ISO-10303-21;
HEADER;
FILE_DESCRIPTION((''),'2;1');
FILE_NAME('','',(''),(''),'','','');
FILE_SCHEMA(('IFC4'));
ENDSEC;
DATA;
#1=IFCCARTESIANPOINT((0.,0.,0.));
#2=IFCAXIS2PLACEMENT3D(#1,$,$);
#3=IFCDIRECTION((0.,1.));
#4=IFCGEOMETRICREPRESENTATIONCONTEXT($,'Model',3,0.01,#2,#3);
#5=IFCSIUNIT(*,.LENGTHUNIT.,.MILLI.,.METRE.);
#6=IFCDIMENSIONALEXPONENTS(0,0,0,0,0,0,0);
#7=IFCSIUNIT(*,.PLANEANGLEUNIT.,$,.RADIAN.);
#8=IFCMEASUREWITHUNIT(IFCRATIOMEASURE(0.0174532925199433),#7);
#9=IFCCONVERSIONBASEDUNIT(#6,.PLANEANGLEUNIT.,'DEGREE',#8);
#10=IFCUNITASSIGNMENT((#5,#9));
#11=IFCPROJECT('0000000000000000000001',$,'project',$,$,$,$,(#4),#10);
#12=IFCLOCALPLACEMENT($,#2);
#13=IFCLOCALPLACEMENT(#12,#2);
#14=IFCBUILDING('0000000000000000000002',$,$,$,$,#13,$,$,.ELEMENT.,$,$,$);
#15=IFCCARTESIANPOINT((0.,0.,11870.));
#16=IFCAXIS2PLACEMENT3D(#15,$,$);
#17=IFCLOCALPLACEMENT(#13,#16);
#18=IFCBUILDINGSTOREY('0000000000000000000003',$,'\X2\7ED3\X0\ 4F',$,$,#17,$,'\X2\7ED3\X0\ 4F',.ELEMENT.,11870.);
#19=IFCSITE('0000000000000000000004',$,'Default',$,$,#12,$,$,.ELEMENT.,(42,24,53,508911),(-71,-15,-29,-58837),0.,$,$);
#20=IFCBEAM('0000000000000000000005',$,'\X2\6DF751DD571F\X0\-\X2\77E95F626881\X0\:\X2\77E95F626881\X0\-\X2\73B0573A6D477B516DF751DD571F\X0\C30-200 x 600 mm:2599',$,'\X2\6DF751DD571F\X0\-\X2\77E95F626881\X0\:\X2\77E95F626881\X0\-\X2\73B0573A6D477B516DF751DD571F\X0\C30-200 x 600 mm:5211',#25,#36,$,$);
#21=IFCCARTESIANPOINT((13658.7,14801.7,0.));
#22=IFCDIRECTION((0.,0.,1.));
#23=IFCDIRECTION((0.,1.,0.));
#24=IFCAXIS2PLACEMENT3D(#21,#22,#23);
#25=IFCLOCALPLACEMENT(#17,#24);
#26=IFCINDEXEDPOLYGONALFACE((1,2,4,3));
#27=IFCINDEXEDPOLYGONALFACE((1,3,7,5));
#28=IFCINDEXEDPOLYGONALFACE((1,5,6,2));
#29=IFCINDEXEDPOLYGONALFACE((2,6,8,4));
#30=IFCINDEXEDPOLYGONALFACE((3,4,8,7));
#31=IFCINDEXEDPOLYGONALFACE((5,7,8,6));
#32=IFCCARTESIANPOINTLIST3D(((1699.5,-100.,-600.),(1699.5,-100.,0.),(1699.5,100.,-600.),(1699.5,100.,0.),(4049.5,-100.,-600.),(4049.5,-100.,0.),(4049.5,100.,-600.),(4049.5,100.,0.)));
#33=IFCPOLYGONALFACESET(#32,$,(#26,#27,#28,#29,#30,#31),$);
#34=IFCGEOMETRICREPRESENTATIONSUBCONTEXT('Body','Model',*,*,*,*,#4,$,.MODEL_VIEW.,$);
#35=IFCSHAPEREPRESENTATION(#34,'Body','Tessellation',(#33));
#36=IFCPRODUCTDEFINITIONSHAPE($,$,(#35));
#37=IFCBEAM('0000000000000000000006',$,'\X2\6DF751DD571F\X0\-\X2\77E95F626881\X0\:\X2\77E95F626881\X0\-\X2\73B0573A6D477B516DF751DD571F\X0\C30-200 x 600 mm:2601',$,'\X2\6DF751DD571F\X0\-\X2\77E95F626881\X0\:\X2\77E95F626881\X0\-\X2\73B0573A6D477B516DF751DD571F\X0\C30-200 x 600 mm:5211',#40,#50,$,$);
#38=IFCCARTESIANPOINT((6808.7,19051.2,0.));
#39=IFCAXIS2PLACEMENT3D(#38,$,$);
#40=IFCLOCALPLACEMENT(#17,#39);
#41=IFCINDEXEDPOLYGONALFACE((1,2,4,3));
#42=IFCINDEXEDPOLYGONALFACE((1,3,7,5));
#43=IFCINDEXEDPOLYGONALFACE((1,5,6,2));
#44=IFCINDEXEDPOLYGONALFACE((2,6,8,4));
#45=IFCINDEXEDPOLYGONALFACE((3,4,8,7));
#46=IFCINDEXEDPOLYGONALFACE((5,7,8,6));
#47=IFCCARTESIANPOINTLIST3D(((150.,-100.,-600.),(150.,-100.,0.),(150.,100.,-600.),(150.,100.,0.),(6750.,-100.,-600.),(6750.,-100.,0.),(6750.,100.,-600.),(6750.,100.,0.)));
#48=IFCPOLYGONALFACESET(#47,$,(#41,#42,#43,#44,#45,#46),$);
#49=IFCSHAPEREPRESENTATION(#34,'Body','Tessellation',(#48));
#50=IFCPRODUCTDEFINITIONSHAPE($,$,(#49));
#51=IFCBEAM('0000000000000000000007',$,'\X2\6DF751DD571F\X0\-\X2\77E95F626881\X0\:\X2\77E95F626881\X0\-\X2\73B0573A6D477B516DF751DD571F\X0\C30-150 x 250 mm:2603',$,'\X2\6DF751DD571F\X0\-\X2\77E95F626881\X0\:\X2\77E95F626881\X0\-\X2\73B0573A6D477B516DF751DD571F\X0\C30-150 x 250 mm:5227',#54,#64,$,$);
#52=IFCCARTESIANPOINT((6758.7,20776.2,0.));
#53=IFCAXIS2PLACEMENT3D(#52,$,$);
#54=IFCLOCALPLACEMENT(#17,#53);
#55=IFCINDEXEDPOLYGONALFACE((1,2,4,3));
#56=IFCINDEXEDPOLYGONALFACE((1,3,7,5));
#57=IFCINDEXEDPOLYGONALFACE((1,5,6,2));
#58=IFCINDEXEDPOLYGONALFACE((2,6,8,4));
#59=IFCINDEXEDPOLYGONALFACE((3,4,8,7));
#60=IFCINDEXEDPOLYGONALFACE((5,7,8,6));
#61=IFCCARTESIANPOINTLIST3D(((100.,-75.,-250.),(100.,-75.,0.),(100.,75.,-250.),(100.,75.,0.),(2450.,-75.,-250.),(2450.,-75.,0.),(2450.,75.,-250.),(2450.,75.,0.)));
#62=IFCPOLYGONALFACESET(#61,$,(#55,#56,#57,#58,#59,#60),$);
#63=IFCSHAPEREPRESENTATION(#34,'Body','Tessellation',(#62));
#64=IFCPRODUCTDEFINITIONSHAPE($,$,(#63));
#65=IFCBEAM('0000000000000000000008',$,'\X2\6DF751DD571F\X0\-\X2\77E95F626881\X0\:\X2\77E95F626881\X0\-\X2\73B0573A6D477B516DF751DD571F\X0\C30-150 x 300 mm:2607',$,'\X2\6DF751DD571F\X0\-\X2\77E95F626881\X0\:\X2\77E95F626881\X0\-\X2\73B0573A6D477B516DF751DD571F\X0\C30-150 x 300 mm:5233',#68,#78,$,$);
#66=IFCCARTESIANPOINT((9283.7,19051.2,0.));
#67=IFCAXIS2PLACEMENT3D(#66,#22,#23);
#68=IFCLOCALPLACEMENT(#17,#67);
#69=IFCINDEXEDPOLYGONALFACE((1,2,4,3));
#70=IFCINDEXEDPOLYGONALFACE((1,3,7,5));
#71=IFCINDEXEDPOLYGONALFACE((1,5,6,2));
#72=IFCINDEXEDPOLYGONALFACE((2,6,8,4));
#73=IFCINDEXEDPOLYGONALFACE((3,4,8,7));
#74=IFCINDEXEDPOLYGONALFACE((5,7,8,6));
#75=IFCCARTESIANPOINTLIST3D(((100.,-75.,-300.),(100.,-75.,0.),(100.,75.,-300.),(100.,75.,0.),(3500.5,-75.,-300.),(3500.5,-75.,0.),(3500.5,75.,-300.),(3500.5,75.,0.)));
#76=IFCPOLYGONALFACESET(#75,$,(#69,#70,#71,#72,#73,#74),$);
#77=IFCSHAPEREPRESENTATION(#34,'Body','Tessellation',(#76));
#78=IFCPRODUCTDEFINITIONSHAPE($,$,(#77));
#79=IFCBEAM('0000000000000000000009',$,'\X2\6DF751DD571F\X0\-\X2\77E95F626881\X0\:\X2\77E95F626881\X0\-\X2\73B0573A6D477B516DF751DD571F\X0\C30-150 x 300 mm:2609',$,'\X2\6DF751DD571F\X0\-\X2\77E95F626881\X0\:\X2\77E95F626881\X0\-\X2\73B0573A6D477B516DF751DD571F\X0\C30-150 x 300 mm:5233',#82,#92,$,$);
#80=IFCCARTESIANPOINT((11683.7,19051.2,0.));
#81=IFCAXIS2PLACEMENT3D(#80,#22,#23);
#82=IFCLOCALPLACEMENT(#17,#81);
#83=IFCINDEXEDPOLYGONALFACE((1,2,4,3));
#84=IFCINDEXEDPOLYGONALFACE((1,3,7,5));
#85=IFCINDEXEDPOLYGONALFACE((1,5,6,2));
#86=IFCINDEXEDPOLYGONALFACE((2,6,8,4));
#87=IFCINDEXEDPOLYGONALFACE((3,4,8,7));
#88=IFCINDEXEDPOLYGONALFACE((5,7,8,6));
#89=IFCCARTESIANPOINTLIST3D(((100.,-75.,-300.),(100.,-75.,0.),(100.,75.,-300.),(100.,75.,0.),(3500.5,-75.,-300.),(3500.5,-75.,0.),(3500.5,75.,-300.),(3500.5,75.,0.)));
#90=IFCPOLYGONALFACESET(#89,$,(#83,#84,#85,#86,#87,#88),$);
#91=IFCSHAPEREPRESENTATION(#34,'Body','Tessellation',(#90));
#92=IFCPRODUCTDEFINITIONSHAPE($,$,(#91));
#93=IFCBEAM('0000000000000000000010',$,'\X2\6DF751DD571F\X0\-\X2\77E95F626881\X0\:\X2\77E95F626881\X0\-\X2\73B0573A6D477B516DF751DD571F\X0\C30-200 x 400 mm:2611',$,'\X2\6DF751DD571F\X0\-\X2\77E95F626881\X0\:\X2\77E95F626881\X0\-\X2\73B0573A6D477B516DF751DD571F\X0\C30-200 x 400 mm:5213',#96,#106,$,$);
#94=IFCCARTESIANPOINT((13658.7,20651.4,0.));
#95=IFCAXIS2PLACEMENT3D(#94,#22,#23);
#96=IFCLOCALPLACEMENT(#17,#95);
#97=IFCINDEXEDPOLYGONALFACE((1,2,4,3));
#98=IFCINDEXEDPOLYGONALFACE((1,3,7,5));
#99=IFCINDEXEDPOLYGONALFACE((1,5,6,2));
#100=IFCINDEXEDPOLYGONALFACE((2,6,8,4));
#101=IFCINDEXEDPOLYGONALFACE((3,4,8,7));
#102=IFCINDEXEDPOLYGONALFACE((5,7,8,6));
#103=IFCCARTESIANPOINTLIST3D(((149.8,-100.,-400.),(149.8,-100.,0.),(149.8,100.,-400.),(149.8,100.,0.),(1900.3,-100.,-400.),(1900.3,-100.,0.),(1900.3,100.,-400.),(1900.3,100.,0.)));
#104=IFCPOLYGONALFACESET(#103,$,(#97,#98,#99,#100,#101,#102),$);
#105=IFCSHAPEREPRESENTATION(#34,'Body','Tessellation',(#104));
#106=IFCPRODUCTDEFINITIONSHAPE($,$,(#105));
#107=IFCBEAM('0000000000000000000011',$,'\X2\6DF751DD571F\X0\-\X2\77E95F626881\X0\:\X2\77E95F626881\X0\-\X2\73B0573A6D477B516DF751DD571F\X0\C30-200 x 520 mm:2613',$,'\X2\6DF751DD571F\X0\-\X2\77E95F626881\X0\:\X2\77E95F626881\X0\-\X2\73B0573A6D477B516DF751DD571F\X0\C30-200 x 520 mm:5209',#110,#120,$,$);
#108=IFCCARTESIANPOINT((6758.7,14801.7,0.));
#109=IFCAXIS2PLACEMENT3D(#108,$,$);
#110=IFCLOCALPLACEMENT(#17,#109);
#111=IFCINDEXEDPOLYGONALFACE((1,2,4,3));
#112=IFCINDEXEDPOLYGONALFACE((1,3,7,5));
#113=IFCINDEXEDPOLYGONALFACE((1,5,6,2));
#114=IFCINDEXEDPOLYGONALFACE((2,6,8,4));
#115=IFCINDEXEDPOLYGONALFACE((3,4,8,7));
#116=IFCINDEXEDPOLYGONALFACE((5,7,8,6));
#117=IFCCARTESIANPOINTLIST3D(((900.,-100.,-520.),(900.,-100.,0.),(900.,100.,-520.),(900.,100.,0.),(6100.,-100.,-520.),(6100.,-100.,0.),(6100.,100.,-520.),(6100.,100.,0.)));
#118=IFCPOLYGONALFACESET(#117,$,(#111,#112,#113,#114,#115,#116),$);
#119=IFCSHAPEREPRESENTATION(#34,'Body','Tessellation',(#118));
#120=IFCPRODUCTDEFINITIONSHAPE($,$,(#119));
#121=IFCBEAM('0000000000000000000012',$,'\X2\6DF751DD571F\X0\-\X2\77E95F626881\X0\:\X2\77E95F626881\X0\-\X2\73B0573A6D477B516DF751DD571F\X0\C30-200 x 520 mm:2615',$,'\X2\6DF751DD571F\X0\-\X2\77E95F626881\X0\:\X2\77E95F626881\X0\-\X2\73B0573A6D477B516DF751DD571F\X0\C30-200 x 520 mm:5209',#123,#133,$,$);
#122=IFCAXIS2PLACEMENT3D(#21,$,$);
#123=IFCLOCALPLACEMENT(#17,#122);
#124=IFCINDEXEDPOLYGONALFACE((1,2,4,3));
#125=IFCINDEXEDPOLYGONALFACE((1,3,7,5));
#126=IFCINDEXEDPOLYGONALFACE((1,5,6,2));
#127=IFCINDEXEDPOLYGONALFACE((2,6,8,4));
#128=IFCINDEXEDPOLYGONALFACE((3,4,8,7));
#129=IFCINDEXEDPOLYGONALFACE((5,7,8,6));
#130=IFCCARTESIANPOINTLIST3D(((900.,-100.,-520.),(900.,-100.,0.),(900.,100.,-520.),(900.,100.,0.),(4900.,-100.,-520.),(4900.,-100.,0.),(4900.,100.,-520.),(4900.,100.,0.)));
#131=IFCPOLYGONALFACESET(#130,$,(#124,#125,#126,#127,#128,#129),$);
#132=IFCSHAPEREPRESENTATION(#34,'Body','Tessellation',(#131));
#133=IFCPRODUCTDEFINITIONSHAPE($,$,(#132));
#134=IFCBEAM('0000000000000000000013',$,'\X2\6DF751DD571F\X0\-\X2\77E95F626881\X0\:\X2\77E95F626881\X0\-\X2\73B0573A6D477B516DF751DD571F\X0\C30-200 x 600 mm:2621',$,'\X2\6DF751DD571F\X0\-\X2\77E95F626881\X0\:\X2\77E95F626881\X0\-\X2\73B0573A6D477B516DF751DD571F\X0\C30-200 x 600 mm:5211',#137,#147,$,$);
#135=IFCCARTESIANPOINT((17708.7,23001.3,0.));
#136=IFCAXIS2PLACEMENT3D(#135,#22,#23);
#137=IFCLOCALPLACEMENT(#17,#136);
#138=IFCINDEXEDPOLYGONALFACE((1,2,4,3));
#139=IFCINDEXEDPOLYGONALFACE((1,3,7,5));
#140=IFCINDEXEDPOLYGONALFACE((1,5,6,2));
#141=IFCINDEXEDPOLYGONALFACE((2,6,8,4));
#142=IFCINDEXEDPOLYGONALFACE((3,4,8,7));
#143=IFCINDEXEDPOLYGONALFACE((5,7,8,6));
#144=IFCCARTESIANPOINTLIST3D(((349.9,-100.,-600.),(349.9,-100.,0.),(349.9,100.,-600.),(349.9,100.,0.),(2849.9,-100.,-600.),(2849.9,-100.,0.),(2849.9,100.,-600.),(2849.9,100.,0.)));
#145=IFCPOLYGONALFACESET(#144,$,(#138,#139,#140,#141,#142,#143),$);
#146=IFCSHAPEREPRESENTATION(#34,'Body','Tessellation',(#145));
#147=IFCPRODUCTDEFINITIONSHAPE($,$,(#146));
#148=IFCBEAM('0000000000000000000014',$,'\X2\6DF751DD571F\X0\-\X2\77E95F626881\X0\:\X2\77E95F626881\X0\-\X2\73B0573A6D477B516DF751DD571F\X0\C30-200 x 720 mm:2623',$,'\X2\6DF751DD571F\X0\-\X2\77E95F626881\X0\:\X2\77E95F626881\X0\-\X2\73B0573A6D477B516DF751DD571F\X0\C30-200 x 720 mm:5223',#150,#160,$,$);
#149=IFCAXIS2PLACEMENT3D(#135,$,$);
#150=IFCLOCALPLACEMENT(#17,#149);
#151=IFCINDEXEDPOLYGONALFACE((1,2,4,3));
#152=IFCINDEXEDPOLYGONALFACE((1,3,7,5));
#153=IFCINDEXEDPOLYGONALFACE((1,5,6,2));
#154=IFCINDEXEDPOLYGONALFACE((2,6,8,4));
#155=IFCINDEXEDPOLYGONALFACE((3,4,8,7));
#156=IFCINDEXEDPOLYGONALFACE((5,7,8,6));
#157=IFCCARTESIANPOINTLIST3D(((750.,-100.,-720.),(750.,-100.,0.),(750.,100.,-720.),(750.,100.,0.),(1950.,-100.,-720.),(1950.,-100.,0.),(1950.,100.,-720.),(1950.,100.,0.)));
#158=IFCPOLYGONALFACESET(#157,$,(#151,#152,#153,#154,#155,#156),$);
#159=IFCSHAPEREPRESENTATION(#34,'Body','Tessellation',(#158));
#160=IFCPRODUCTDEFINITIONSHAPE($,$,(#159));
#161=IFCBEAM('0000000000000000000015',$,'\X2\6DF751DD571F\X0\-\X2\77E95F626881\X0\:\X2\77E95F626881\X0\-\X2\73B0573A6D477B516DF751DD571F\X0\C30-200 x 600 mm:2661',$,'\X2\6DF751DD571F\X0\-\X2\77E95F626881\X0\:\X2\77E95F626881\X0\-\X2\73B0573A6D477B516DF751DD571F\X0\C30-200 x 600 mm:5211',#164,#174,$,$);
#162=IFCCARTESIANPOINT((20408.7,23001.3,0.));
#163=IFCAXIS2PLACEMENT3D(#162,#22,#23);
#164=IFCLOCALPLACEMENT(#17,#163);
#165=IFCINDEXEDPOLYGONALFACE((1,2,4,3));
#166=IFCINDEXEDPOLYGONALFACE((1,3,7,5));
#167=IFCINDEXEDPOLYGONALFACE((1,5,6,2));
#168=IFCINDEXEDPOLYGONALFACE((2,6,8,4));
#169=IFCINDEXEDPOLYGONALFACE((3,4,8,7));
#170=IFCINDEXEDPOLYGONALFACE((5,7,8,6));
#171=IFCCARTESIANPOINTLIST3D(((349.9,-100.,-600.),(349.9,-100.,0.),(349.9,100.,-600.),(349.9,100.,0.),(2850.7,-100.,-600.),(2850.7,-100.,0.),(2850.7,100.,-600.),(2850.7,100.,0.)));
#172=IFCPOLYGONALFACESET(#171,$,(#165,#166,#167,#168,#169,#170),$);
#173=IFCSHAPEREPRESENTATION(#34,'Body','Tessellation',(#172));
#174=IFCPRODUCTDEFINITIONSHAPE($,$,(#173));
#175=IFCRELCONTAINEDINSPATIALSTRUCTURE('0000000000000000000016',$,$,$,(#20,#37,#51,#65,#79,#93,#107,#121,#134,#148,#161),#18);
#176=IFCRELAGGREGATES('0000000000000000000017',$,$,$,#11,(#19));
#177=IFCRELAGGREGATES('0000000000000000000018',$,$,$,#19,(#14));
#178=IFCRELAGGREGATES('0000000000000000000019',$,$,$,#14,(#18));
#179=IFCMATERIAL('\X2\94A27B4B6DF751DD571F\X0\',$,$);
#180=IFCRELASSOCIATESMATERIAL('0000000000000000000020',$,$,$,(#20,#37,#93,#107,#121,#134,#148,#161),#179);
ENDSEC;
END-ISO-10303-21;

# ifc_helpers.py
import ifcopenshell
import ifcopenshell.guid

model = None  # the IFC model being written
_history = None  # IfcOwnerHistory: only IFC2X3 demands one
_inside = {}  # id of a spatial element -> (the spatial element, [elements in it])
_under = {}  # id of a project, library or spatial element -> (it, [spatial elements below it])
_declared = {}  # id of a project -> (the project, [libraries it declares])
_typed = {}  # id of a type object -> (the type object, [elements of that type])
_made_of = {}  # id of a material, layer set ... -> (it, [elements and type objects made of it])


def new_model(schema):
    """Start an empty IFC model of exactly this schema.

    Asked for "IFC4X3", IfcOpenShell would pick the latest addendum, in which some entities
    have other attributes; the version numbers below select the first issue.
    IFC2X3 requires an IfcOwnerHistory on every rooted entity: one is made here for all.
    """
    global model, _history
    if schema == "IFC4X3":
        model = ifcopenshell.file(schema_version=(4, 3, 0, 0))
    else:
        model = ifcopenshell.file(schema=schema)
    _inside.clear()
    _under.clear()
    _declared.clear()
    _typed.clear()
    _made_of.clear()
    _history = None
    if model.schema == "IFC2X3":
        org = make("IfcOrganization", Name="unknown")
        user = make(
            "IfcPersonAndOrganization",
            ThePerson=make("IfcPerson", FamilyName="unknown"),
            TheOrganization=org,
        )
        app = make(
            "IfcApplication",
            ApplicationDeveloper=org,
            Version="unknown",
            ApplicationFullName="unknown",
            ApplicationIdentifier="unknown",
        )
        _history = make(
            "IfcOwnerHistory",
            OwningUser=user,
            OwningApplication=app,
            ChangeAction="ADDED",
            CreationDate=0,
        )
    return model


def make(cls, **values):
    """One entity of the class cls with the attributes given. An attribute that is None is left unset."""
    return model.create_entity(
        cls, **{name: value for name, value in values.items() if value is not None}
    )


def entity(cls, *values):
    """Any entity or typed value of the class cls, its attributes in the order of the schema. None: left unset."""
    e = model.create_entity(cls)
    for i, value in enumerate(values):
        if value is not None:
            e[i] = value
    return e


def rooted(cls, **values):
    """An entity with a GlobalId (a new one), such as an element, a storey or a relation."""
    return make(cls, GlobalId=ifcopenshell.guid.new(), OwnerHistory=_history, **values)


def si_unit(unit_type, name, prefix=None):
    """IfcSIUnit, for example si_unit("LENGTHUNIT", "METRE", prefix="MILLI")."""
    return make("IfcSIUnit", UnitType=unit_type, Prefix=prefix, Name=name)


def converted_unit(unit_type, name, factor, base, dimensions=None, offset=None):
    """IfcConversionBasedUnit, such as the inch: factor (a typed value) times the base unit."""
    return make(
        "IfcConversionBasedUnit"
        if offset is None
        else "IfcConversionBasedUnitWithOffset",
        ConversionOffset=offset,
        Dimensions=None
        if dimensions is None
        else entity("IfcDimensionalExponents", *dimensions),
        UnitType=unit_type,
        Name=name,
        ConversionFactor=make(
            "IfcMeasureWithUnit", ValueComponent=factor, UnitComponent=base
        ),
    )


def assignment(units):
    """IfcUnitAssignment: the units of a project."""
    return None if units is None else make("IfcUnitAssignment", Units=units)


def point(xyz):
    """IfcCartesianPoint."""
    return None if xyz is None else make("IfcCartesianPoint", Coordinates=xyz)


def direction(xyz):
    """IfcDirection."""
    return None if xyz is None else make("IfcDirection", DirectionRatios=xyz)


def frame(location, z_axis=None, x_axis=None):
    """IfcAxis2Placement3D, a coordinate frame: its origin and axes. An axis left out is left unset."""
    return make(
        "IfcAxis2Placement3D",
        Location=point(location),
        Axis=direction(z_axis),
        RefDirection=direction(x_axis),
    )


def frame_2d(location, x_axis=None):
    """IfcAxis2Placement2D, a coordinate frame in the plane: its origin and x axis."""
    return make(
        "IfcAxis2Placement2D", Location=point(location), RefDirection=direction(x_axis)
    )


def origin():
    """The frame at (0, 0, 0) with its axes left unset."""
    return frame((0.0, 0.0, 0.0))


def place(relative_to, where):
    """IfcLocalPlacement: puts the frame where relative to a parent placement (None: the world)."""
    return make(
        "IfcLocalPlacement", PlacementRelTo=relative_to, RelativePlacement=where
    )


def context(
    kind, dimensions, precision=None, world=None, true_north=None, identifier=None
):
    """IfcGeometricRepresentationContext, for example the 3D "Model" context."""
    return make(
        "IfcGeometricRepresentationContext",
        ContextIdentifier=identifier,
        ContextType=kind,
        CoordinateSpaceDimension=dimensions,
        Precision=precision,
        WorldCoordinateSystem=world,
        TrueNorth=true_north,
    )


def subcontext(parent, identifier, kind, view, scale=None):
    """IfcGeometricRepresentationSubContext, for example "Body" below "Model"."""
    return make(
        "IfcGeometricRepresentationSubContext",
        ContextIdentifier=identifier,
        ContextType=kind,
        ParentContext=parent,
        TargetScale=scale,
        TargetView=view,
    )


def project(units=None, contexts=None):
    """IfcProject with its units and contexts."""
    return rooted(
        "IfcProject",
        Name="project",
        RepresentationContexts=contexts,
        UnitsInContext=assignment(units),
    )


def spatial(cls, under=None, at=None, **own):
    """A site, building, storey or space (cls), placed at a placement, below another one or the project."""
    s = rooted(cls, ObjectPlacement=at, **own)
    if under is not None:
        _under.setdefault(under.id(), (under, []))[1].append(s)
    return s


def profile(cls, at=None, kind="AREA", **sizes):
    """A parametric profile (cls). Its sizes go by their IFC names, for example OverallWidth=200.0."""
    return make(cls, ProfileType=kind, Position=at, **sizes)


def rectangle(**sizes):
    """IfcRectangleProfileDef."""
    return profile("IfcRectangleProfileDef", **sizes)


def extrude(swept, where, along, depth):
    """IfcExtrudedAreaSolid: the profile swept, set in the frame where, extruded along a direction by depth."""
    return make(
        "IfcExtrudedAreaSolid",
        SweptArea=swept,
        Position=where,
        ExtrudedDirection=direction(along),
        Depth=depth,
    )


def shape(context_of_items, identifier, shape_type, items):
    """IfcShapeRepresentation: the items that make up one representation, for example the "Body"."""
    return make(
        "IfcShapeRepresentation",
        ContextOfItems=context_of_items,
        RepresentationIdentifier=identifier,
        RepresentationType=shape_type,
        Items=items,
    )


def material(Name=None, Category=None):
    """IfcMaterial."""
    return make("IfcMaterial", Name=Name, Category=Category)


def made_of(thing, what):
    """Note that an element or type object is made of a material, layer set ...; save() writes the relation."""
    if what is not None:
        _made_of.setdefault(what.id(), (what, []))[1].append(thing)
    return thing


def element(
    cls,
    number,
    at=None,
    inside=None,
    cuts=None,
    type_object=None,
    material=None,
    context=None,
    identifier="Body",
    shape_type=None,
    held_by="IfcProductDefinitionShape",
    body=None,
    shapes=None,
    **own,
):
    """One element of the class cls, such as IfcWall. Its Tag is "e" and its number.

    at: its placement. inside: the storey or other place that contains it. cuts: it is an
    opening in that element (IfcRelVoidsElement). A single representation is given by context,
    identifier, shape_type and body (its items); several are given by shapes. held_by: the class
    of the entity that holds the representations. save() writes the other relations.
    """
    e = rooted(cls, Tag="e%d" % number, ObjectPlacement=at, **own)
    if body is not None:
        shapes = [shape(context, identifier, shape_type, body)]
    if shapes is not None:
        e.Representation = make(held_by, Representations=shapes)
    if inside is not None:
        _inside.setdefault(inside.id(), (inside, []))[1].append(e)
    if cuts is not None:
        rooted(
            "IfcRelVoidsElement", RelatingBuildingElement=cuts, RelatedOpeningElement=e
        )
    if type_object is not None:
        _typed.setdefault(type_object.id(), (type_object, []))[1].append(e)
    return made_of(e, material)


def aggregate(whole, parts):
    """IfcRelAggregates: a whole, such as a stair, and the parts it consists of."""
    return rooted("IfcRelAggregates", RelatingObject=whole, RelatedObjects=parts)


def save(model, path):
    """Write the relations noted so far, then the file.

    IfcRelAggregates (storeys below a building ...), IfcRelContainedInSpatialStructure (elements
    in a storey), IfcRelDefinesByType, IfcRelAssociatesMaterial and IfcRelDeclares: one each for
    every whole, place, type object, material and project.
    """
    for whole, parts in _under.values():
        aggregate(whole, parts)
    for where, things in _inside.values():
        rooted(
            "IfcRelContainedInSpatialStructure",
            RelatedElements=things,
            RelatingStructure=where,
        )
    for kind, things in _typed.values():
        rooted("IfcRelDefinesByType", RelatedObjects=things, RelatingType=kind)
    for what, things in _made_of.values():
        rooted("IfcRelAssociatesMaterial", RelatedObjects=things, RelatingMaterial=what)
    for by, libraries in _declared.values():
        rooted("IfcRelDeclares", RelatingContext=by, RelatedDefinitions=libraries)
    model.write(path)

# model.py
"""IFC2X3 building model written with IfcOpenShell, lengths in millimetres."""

from ifc_helpers import new_model, entity, si_unit, converted_unit, direction, frame, frame_2d, origin, place, context, subcontext, project, spatial, rectangle, extrude, material, element, save


model = new_model("IFC2X3")

# Units and contexts
model_context = context("Model", 3, precision=0.01, world=origin(), true_north=direction((0.0, 1.0)))
body_context = subcontext(model_context, "Body", "Model", "MODEL_VIEW")
ifc_project = project(units=[si_unit("LENGTHUNIT", "METRE", prefix="MILLI"), converted_unit("PLANEANGLEUNIT", "DEGREE", entity("IfcRatioMeasure", 0.0174532925199433), si_unit("PLANEANGLEUNIT", "RADIAN"), dimensions=[0, 0, 0, 0, 0, 0, 0])], contexts=[model_context])

# Site, building, storey
site_placement = place(None, origin())
site = spatial("IfcSite", under=ifc_project, at=site_placement, Name="Default", CompositionType="ELEMENT", RefLatitude=(42, 24, 53, 508911), RefLongitude=(-71, -15, -29, -58837), RefElevation=0.0)
building_placement = place(site_placement, origin())
building = spatial("IfcBuilding", under=site, at=building_placement, CompositionType="ELEMENT")
storey_placement = place(building_placement, frame((0.0, 0.0, 11870.0)))
storey = spatial("IfcBuildingStorey", under=building, at=storey_placement, Name="结 4F", LongName="结 4F", CompositionType="ELEMENT", Elevation=11870.0)

# Beams
ifc_material = material(Name="钢筋混凝土")
beam_1_placement = place(storey_placement, frame((13658.7, 14801.7, 0.0), z_axis=(0.0, 0.0, 1.0), x_axis=(0.0, 1.0, 0.0)))
element("IfcBeam", 1, at=beam_1_placement, inside=storey, material=ifc_material, Name="混凝土-矩形梁:矩形梁-现场浇筑混凝土C30-200 x 600 mm:2599", ObjectType="混凝土-矩形梁:矩形梁-现场浇筑混凝土C30-200 x 600 mm:5211", context=body_context, shape_type="SweptSolid", body=[
    extrude(rectangle(XDim=600.0, YDim=200.0, at=frame_2d((0.0, 0.0), x_axis=(1.0, 0.0))), frame((1699.5, 0.0, -300.0), z_axis=(1.0, 0.0, 0.0), x_axis=(0.0, 0.0, -1.0)), (0.0, 0.0, 1.0), 2350.0),
])
beam_2_placement = place(storey_placement, frame((6808.7, 19051.2, 0.0)))
element("IfcBeam", 2, at=beam_2_placement, inside=storey, material=ifc_material, Name="混凝土-矩形梁:矩形梁-现场浇筑混凝土C30-200 x 600 mm:2601", ObjectType="混凝土-矩形梁:矩形梁-现场浇筑混凝土C30-200 x 600 mm:5211", context=body_context, shape_type="SweptSolid", body=[
    extrude(rectangle(XDim=600.0, YDim=200.0, at=frame_2d((0.0, 0.0), x_axis=(1.0, 0.0))), frame((150.0, 0.0, -300.0), z_axis=(1.0, 0.0, 0.0), x_axis=(0.0, 0.0, -1.0)), (0.0, 0.0, 1.0), 6600.0),
])
beam_3_placement = place(storey_placement, frame((6758.7, 20776.2, 0.0)))
element("IfcBeam", 3, at=beam_3_placement, inside=storey, Name="混凝土-矩形梁:矩形梁-现场浇筑混凝土C30-150 x 250 mm:2603", ObjectType="混凝土-矩形梁:矩形梁-现场浇筑混凝土C30-150 x 250 mm:5227", context=body_context, shape_type="SweptSolid", body=[
    extrude(rectangle(XDim=250.0, YDim=150.0, at=frame_2d((0.0, 0.0), x_axis=(1.0, 0.0))), frame((100.0, 0.0, -125.0), z_axis=(1.0, 0.0, 0.0), x_axis=(0.0, 0.0, -1.0)), (0.0, 0.0, 1.0), 2350.0),
])
beam_4_placement = place(storey_placement, frame((9283.7, 19051.2, 0.0), z_axis=(0.0, 0.0, 1.0), x_axis=(0.0, 1.0, 0.0)))
element("IfcBeam", 4, at=beam_4_placement, inside=storey, Name="混凝土-矩形梁:矩形梁-现场浇筑混凝土C30-150 x 300 mm:2607", ObjectType="混凝土-矩形梁:矩形梁-现场浇筑混凝土C30-150 x 300 mm:5233", context=body_context, shape_type="SweptSolid", body=[
    extrude(rectangle(XDim=300.0, YDim=150.0, at=frame_2d((0.0, 0.0), x_axis=(1.0, 0.0))), frame((100.0, 0.0, -150.0), z_axis=(1.0, 0.0, 0.0), x_axis=(0.0, 0.0, -1.0)), (0.0, 0.0, 1.0), 3400.5),
])
beam_5_placement = place(storey_placement, frame((11683.7, 19051.2, 0.0), z_axis=(0.0, 0.0, 1.0), x_axis=(0.0, 1.0, 0.0)))
element("IfcBeam", 5, at=beam_5_placement, inside=storey, Name="混凝土-矩形梁:矩形梁-现场浇筑混凝土C30-150 x 300 mm:2609", ObjectType="混凝土-矩形梁:矩形梁-现场浇筑混凝土C30-150 x 300 mm:5233", context=body_context, shape_type="SweptSolid", body=[
    extrude(rectangle(XDim=300.0, YDim=150.0, at=frame_2d((0.0, 0.0), x_axis=(1.0, 0.0))), frame((100.0, 0.0, -150.0), z_axis=(1.0, 0.0, 0.0), x_axis=(0.0, 0.0, -1.0)), (0.0, 0.0, 1.0), 3400.5),
])
beam_6_placement = place(storey_placement, frame((13658.7, 20651.4, 0.0), z_axis=(0.0, 0.0, 1.0), x_axis=(0.0, 1.0, 0.0)))
element("IfcBeam", 6, at=beam_6_placement, inside=storey, material=ifc_material, Name="混凝土-矩形梁:矩形梁-现场浇筑混凝土C30-200 x 400 mm:2611", ObjectType="混凝土-矩形梁:矩形梁-现场浇筑混凝土C30-200 x 400 mm:5213", context=body_context, shape_type="SweptSolid", body=[
    extrude(rectangle(XDim=400.0, YDim=200.0, at=frame_2d((0.0, 0.0), x_axis=(1.0, 0.0))), frame((149.8, 0.0, -200.0), z_axis=(1.0, 0.0, 0.0), x_axis=(0.0, 0.0, -1.0)), (0.0, 0.0, 1.0), 1750.5),
])
beam_7_placement = place(storey_placement, frame((6758.7, 14801.7, 0.0)))
element("IfcBeam", 7, at=beam_7_placement, inside=storey, material=ifc_material, Name="混凝土-矩形梁:矩形梁-现场浇筑混凝土C30-200 x 520 mm:2613", ObjectType="混凝土-矩形梁:矩形梁-现场浇筑混凝土C30-200 x 520 mm:5209", context=body_context, shape_type="SweptSolid", body=[
    extrude(rectangle(XDim=520.0, YDim=200.0, at=frame_2d((0.0, 0.0), x_axis=(1.0, 0.0))), frame((900.0, 0.0, -260.0), z_axis=(1.0, 0.0, 0.0), x_axis=(0.0, 0.0, -1.0)), (0.0, 0.0, 1.0), 5200.0),
])
beam_8_placement = place(storey_placement, frame((13658.7, 14801.7, 0.0)))
element("IfcBeam", 8, at=beam_8_placement, inside=storey, material=ifc_material, Name="混凝土-矩形梁:矩形梁-现场浇筑混凝土C30-200 x 520 mm:2615", ObjectType="混凝土-矩形梁:矩形梁-现场浇筑混凝土C30-200 x 520 mm:5209", context=body_context, shape_type="SweptSolid", body=[
    extrude(rectangle(XDim=520.0, YDim=200.0, at=frame_2d((0.0, 0.0), x_axis=(1.0, 0.0))), frame((900.0, 0.0, -260.0), z_axis=(1.0, 0.0, 0.0), x_axis=(0.0, 0.0, -1.0)), (0.0, 0.0, 1.0), 4000.0),
])
beam_9_placement = place(storey_placement, frame((17708.7, 23001.3, 0.0), z_axis=(0.0, 0.0, 1.0), x_axis=(0.0, 1.0, 0.0)))
element("IfcBeam", 9, at=beam_9_placement, inside=storey, material=ifc_material, Name="混凝土-矩形梁:矩形梁-现场浇筑混凝土C30-200 x 600 mm:2621", ObjectType="混凝土-矩形梁:矩形梁-现场浇筑混凝土C30-200 x 600 mm:5211", context=body_context, shape_type="SweptSolid", body=[
    extrude(rectangle(XDim=600.0, YDim=200.0, at=frame_2d((0.0, 0.0), x_axis=(1.0, 0.0))), frame((349.9, 0.0, -300.0), z_axis=(1.0, 0.0, 0.0), x_axis=(0.0, 0.0, -1.0)), (0.0, 0.0, 1.0), 2500.0),
])
beam_10_placement = place(storey_placement, frame((17708.7, 23001.3, 0.0)))
element("IfcBeam", 10, at=beam_10_placement, inside=storey, material=ifc_material, Name="混凝土-矩形梁:矩形梁-现场浇筑混凝土C30-200 x 720 mm:2623", ObjectType="混凝土-矩形梁:矩形梁-现场浇筑混凝土C30-200 x 720 mm:5223", context=body_context, shape_type="SweptSolid", body=[
    extrude(rectangle(XDim=720.0, YDim=200.0, at=frame_2d((0.0, 0.0), x_axis=(1.0, 0.0))), frame((750.0, 0.0, -360.0), z_axis=(1.0, 0.0, 0.0), x_axis=(0.0, 0.0, -1.0)), (0.0, 0.0, 1.0), 1200.0),
])
beam_11_placement = place(storey_placement, frame((20408.7, 23001.3, 0.0), z_axis=(0.0, 0.0, 1.0), x_axis=(0.0, 1.0, 0.0)))
element("IfcBeam", 11, at=beam_11_placement, inside=storey, material=ifc_material, Name="混凝土-矩形梁:矩形梁-现场浇筑混凝土C30-200 x 600 mm:2661", ObjectType="混凝土-矩形梁:矩形梁-现场浇筑混凝土C30-200 x 600 mm:5211", context=body_context, shape_type="SweptSolid", body=[
    extrude(rectangle(XDim=600.0, YDim=200.0, at=frame_2d((0.0, 0.0), x_axis=(1.0, 0.0))), frame((349.9, 0.0, -300.0), z_axis=(1.0, 0.0, 0.0), x_axis=(0.0, 0.0, -1.0)), (0.0, 0.0, 1.0), 2500.8),
])

save(model, "model.ifc")
